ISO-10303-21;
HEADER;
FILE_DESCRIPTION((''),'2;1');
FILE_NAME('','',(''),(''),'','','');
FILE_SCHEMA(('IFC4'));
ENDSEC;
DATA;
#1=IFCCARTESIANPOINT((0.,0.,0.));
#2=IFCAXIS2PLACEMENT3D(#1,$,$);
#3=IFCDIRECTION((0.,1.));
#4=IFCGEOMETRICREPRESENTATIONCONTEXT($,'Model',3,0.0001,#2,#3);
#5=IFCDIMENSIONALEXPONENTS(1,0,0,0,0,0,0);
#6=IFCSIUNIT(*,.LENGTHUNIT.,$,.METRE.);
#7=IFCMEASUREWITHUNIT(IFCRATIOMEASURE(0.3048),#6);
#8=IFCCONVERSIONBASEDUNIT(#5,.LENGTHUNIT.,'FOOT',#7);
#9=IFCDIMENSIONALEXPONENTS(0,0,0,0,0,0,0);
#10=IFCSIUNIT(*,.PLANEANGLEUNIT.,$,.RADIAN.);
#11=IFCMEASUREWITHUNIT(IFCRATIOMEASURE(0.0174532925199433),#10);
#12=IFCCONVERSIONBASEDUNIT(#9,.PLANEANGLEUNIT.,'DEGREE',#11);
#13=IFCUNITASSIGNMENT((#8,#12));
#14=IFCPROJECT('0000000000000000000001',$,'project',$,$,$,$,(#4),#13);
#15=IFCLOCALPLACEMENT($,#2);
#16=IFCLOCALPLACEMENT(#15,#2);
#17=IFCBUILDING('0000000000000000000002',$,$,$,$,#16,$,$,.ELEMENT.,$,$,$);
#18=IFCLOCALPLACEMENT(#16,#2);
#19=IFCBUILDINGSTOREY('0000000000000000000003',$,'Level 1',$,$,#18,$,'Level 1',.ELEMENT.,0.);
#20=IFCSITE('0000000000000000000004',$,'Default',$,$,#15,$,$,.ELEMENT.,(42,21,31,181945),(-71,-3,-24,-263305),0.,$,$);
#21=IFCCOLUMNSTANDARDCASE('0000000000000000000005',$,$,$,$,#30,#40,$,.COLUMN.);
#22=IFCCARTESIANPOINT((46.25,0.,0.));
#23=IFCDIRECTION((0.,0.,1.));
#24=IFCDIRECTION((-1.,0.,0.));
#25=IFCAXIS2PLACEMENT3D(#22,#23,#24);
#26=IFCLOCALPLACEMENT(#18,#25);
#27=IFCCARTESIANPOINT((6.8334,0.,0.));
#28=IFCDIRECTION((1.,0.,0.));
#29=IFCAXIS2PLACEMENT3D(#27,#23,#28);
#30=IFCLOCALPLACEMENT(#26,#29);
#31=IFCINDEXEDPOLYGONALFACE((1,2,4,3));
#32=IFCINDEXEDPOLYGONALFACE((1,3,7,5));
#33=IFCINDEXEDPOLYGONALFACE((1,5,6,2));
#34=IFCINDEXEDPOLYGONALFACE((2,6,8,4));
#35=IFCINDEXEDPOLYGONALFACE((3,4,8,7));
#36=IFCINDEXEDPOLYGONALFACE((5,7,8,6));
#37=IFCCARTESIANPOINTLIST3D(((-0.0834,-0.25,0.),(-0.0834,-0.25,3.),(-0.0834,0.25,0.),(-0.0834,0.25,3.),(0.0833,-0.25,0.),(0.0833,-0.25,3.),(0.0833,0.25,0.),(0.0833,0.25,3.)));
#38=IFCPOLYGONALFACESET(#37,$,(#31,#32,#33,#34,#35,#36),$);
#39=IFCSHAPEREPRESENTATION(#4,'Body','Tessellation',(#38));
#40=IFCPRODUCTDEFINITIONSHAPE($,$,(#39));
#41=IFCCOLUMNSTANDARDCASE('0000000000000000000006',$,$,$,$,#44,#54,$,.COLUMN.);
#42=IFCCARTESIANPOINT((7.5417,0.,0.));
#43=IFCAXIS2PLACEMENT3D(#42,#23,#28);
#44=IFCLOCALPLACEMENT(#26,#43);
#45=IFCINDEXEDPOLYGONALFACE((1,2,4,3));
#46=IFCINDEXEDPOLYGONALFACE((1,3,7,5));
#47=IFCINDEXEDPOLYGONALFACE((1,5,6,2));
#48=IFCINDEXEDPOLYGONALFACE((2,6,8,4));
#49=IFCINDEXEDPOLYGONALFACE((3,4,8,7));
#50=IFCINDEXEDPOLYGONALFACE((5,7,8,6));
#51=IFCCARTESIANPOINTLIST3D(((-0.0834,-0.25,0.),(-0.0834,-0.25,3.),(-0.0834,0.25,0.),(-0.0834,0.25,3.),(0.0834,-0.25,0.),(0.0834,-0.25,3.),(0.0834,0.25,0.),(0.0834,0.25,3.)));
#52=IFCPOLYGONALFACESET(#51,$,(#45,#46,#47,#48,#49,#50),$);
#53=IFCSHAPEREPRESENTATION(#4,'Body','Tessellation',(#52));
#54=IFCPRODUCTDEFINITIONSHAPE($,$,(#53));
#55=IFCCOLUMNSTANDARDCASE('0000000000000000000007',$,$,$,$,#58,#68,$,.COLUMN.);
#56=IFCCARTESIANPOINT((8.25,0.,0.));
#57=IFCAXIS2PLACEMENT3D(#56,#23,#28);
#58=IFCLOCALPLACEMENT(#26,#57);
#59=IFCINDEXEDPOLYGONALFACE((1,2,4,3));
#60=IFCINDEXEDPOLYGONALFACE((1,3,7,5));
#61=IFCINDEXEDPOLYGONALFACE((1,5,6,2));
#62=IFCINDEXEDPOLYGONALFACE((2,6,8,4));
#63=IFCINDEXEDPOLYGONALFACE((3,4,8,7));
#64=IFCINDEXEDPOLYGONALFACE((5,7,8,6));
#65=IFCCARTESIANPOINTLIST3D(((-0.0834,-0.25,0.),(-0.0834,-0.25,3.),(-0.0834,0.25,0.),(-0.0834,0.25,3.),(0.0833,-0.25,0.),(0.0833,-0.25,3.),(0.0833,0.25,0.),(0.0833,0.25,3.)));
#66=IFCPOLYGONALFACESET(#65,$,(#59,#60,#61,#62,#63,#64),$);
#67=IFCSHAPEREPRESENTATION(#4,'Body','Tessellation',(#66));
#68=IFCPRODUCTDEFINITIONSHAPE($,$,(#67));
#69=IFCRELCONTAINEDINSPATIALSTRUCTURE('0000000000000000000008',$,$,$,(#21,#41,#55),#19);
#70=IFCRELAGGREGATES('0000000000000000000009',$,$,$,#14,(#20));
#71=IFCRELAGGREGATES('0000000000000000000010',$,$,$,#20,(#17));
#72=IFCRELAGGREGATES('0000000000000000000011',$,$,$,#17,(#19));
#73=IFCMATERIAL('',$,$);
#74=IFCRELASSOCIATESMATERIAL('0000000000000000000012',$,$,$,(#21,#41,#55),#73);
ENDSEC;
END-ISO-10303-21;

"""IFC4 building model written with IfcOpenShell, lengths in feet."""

from ifc_helpers import new_model, entity, si_unit, converted_unit, direction, frame, origin, place, context, project, spatial, rectangle, extrude, material, element, save


model = new_model("IFC4")

# Units and contexts
model_context = context("Model", 3, precision=0.0001, world=origin(), true_north=direction((0.0, 1.0)))
ifc_project = project(units=[converted_unit("LENGTHUNIT", "FOOT", entity("IfcRatioMeasure", 0.3048), si_unit("LENGTHUNIT", "METRE"), dimensions=[1, 0, 0, 0, 0, 0, 0]), converted_unit("PLANEANGLEUNIT", "DEGREE", entity("IfcRatioMeasure", 0.0174532925199433), si_unit("PLANEANGLEUNIT", "RADIAN"), dimensions=[0, 0, 0, 0, 0, 0, 0])], contexts=[model_context])

# Site, building, storey
site_placement = place(None, origin())
site = spatial("IfcSite", under=ifc_project, at=site_placement, Name="Default", CompositionType="ELEMENT", RefLatitude=(42, 21, 31, 181945), RefLongitude=(-71, -3, -24, -263305), RefElevation=0.0)
building_placement = place(site_placement, origin())
building = spatial("IfcBuilding", under=site, at=building_placement, CompositionType="ELEMENT")
storey_placement = place(building_placement, origin())
storey = spatial("IfcBuildingStorey", under=building, at=storey_placement, Name="Level 1", LongName="Level 1", CompositionType="ELEMENT", Elevation=0.0)

# Columns
placement_1 = place(storey_placement, frame((46.25, 0.0, 0.0), z_axis=(0.0, 0.0, 1.0), x_axis=(-1.0, 0.0, 0.0)))
ifc_material_1 = material(Name="")
for number, where, z_axis, x_axis in (
    (1, (6.8334, 0.0, 0.0), (0.0, 0.0, 1.0), (1.0, 0.0, 0.0)),
    (2, (7.5417, 0.0, 0.0), (0.0, 0.0, 1.0), (1.0, 0.0, 0.0)),
    (3, (8.25, 0.0, 0.0), (0.0, 0.0, 1.0), (1.0, 0.0, 0.0)),
):
    element("IfcColumnStandardCase", number, at=place(placement_1, frame(where, z_axis=z_axis, x_axis=x_axis)), inside=storey, material=ifc_material_1, PredefinedType="COLUMN", context=model_context, shape_type="SweptSolid", body=[
        extrude(rectangle(XDim=0.1667, YDim=0.5), origin(), (0.0, 0.0, 1.0), 3.0),
    ])

save(model, "model.ifc")
